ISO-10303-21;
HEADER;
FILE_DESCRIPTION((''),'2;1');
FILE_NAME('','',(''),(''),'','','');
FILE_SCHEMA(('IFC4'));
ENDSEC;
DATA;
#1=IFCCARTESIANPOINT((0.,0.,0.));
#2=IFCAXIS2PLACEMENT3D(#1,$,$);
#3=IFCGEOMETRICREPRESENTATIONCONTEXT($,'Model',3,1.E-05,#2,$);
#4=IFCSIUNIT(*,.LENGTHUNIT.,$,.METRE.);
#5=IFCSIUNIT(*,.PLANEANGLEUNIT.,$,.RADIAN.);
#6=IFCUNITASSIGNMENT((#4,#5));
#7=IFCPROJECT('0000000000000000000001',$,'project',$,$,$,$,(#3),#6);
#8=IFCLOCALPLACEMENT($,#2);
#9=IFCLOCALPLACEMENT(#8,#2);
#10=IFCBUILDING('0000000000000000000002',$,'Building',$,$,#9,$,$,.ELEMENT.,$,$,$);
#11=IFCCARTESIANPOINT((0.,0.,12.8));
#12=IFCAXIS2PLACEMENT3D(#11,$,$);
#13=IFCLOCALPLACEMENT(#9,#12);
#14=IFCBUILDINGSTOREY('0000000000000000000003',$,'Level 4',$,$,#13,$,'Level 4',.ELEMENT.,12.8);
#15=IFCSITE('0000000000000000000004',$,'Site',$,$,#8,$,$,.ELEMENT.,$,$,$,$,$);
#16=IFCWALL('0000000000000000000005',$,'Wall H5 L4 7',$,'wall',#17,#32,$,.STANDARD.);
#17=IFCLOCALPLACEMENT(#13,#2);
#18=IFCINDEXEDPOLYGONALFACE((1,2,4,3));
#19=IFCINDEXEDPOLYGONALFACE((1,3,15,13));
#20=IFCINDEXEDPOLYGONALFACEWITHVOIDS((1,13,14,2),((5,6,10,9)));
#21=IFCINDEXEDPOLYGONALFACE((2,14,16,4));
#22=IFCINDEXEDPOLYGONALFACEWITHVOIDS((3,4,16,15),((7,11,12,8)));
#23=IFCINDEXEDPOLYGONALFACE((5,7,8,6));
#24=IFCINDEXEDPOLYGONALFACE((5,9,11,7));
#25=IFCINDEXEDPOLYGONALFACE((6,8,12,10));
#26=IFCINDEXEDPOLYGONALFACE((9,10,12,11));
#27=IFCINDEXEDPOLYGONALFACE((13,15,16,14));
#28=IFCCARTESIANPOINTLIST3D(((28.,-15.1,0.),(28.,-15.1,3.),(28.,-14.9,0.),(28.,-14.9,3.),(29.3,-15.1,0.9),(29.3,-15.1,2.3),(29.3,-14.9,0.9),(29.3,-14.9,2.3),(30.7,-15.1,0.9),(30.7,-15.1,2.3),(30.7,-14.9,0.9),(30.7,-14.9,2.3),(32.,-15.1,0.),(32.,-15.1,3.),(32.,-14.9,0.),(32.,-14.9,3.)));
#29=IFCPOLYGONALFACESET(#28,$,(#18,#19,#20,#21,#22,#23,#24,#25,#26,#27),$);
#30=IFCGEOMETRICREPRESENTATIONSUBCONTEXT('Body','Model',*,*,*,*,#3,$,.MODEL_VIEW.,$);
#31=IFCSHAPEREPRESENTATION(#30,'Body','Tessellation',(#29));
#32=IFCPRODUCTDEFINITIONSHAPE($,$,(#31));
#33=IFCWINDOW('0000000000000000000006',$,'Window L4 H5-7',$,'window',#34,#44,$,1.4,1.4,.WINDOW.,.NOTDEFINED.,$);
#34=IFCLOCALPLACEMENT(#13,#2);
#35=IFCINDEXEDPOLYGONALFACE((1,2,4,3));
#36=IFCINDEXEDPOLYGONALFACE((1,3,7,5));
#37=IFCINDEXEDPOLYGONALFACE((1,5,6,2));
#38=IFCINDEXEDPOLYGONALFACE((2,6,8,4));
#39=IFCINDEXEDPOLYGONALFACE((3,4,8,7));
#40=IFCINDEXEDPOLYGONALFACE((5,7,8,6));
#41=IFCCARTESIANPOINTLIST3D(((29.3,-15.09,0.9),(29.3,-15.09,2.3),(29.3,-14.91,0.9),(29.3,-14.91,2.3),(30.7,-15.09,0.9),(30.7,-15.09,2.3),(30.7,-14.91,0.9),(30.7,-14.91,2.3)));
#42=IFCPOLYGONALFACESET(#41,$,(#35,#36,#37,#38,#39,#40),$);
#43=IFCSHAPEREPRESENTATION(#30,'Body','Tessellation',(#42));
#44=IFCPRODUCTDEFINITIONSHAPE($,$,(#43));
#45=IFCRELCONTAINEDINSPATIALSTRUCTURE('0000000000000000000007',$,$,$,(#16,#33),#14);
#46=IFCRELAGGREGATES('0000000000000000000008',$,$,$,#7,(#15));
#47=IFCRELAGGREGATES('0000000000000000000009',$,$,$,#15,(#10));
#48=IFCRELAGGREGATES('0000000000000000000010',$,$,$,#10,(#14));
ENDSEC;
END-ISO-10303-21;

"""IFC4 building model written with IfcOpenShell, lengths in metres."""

from ifc_helpers import new_model, si_unit, frame, frame_2d, origin, origin_2d, place, context, subcontext, project, spatial, rectangle, extrude, element, fill, save


model = new_model("IFC4")

# Units and contexts
model_context = context("Model", 3, precision=1e-05, world=origin())
body_context = subcontext(model_context, "Body", "Model", "MODEL_VIEW")
ifc_project = project(units=[si_unit("LENGTHUNIT", "METRE"), si_unit("PLANEANGLEUNIT", "RADIAN")], contexts=[model_context])

# Site, building, storey
site_placement = place(None, origin())
site = spatial("IfcSite", under=ifc_project, at=site_placement, Name="Site", CompositionType="ELEMENT")
building_placement = place(site_placement, origin())
building = spatial("IfcBuilding", under=site, at=building_placement, Name="Building", CompositionType="ELEMENT")
storey_placement = place(building_placement, frame((0.0, 0.0, 12.8)))
storey = spatial("IfcBuildingStorey", under=building, at=storey_placement, Name="Level 4", LongName="Level 4", CompositionType="ELEMENT", Elevation=12.8)

# Wall, opening, window
wall_1_placement = place(storey_placement, frame((28.0, -15.0, 0.0), z_axis=(0.0, 0.0, 1.0), x_axis=(1.0, 0.0, 0.0)))
wall_1 = element("IfcWall", 1, at=wall_1_placement, inside=storey, Name="Wall H5 L4 7", ObjectType="wall", PredefinedType="STANDARD", context=body_context, shape_type="SweptSolid", body=[
    extrude(rectangle(XDim=4.0, YDim=0.2, at=frame_2d((2.0, 0.0))), origin(), (0.0, 0.0, 1.0), 3.0),
])
opening_1_placement = place(storey_placement, frame((30.0, -15.0, 0.9), z_axis=(0.0, 0.0, 1.0), x_axis=(1.0, 0.0, 0.0)))
opening_1 = element("IfcOpeningElement", 2, at=opening_1_placement, cuts=wall_1, ObjectType="Opening", PredefinedType="OPENING", context=body_context, shape_type="SweptSolid", body=[
    extrude(rectangle(XDim=1.4, YDim=0.22, at=origin_2d()), origin(), (0.0, 0.0, 1.0), 1.4),
])
window_1_placement = place(storey_placement, frame((30.0, -15.0, 0.9), z_axis=(0.0, 0.0, 1.0), x_axis=(1.0, 0.0, 0.0)))
window_1 = element("IfcWindow", 3, at=window_1_placement, inside=storey, Name="Window L4 H5-7", ObjectType="window", OverallHeight=1.4, OverallWidth=1.4, PartitioningType="NOTDEFINED", PredefinedType="WINDOW", context=body_context, shape_type="SweptSolid", body=[
    extrude(rectangle(XDim=1.4, YDim=0.18, at=origin_2d()), origin(), (0.0, 0.0, 1.0), 1.4),
])
fill(opening_1, window_1)

save(model, "model.ifc")
